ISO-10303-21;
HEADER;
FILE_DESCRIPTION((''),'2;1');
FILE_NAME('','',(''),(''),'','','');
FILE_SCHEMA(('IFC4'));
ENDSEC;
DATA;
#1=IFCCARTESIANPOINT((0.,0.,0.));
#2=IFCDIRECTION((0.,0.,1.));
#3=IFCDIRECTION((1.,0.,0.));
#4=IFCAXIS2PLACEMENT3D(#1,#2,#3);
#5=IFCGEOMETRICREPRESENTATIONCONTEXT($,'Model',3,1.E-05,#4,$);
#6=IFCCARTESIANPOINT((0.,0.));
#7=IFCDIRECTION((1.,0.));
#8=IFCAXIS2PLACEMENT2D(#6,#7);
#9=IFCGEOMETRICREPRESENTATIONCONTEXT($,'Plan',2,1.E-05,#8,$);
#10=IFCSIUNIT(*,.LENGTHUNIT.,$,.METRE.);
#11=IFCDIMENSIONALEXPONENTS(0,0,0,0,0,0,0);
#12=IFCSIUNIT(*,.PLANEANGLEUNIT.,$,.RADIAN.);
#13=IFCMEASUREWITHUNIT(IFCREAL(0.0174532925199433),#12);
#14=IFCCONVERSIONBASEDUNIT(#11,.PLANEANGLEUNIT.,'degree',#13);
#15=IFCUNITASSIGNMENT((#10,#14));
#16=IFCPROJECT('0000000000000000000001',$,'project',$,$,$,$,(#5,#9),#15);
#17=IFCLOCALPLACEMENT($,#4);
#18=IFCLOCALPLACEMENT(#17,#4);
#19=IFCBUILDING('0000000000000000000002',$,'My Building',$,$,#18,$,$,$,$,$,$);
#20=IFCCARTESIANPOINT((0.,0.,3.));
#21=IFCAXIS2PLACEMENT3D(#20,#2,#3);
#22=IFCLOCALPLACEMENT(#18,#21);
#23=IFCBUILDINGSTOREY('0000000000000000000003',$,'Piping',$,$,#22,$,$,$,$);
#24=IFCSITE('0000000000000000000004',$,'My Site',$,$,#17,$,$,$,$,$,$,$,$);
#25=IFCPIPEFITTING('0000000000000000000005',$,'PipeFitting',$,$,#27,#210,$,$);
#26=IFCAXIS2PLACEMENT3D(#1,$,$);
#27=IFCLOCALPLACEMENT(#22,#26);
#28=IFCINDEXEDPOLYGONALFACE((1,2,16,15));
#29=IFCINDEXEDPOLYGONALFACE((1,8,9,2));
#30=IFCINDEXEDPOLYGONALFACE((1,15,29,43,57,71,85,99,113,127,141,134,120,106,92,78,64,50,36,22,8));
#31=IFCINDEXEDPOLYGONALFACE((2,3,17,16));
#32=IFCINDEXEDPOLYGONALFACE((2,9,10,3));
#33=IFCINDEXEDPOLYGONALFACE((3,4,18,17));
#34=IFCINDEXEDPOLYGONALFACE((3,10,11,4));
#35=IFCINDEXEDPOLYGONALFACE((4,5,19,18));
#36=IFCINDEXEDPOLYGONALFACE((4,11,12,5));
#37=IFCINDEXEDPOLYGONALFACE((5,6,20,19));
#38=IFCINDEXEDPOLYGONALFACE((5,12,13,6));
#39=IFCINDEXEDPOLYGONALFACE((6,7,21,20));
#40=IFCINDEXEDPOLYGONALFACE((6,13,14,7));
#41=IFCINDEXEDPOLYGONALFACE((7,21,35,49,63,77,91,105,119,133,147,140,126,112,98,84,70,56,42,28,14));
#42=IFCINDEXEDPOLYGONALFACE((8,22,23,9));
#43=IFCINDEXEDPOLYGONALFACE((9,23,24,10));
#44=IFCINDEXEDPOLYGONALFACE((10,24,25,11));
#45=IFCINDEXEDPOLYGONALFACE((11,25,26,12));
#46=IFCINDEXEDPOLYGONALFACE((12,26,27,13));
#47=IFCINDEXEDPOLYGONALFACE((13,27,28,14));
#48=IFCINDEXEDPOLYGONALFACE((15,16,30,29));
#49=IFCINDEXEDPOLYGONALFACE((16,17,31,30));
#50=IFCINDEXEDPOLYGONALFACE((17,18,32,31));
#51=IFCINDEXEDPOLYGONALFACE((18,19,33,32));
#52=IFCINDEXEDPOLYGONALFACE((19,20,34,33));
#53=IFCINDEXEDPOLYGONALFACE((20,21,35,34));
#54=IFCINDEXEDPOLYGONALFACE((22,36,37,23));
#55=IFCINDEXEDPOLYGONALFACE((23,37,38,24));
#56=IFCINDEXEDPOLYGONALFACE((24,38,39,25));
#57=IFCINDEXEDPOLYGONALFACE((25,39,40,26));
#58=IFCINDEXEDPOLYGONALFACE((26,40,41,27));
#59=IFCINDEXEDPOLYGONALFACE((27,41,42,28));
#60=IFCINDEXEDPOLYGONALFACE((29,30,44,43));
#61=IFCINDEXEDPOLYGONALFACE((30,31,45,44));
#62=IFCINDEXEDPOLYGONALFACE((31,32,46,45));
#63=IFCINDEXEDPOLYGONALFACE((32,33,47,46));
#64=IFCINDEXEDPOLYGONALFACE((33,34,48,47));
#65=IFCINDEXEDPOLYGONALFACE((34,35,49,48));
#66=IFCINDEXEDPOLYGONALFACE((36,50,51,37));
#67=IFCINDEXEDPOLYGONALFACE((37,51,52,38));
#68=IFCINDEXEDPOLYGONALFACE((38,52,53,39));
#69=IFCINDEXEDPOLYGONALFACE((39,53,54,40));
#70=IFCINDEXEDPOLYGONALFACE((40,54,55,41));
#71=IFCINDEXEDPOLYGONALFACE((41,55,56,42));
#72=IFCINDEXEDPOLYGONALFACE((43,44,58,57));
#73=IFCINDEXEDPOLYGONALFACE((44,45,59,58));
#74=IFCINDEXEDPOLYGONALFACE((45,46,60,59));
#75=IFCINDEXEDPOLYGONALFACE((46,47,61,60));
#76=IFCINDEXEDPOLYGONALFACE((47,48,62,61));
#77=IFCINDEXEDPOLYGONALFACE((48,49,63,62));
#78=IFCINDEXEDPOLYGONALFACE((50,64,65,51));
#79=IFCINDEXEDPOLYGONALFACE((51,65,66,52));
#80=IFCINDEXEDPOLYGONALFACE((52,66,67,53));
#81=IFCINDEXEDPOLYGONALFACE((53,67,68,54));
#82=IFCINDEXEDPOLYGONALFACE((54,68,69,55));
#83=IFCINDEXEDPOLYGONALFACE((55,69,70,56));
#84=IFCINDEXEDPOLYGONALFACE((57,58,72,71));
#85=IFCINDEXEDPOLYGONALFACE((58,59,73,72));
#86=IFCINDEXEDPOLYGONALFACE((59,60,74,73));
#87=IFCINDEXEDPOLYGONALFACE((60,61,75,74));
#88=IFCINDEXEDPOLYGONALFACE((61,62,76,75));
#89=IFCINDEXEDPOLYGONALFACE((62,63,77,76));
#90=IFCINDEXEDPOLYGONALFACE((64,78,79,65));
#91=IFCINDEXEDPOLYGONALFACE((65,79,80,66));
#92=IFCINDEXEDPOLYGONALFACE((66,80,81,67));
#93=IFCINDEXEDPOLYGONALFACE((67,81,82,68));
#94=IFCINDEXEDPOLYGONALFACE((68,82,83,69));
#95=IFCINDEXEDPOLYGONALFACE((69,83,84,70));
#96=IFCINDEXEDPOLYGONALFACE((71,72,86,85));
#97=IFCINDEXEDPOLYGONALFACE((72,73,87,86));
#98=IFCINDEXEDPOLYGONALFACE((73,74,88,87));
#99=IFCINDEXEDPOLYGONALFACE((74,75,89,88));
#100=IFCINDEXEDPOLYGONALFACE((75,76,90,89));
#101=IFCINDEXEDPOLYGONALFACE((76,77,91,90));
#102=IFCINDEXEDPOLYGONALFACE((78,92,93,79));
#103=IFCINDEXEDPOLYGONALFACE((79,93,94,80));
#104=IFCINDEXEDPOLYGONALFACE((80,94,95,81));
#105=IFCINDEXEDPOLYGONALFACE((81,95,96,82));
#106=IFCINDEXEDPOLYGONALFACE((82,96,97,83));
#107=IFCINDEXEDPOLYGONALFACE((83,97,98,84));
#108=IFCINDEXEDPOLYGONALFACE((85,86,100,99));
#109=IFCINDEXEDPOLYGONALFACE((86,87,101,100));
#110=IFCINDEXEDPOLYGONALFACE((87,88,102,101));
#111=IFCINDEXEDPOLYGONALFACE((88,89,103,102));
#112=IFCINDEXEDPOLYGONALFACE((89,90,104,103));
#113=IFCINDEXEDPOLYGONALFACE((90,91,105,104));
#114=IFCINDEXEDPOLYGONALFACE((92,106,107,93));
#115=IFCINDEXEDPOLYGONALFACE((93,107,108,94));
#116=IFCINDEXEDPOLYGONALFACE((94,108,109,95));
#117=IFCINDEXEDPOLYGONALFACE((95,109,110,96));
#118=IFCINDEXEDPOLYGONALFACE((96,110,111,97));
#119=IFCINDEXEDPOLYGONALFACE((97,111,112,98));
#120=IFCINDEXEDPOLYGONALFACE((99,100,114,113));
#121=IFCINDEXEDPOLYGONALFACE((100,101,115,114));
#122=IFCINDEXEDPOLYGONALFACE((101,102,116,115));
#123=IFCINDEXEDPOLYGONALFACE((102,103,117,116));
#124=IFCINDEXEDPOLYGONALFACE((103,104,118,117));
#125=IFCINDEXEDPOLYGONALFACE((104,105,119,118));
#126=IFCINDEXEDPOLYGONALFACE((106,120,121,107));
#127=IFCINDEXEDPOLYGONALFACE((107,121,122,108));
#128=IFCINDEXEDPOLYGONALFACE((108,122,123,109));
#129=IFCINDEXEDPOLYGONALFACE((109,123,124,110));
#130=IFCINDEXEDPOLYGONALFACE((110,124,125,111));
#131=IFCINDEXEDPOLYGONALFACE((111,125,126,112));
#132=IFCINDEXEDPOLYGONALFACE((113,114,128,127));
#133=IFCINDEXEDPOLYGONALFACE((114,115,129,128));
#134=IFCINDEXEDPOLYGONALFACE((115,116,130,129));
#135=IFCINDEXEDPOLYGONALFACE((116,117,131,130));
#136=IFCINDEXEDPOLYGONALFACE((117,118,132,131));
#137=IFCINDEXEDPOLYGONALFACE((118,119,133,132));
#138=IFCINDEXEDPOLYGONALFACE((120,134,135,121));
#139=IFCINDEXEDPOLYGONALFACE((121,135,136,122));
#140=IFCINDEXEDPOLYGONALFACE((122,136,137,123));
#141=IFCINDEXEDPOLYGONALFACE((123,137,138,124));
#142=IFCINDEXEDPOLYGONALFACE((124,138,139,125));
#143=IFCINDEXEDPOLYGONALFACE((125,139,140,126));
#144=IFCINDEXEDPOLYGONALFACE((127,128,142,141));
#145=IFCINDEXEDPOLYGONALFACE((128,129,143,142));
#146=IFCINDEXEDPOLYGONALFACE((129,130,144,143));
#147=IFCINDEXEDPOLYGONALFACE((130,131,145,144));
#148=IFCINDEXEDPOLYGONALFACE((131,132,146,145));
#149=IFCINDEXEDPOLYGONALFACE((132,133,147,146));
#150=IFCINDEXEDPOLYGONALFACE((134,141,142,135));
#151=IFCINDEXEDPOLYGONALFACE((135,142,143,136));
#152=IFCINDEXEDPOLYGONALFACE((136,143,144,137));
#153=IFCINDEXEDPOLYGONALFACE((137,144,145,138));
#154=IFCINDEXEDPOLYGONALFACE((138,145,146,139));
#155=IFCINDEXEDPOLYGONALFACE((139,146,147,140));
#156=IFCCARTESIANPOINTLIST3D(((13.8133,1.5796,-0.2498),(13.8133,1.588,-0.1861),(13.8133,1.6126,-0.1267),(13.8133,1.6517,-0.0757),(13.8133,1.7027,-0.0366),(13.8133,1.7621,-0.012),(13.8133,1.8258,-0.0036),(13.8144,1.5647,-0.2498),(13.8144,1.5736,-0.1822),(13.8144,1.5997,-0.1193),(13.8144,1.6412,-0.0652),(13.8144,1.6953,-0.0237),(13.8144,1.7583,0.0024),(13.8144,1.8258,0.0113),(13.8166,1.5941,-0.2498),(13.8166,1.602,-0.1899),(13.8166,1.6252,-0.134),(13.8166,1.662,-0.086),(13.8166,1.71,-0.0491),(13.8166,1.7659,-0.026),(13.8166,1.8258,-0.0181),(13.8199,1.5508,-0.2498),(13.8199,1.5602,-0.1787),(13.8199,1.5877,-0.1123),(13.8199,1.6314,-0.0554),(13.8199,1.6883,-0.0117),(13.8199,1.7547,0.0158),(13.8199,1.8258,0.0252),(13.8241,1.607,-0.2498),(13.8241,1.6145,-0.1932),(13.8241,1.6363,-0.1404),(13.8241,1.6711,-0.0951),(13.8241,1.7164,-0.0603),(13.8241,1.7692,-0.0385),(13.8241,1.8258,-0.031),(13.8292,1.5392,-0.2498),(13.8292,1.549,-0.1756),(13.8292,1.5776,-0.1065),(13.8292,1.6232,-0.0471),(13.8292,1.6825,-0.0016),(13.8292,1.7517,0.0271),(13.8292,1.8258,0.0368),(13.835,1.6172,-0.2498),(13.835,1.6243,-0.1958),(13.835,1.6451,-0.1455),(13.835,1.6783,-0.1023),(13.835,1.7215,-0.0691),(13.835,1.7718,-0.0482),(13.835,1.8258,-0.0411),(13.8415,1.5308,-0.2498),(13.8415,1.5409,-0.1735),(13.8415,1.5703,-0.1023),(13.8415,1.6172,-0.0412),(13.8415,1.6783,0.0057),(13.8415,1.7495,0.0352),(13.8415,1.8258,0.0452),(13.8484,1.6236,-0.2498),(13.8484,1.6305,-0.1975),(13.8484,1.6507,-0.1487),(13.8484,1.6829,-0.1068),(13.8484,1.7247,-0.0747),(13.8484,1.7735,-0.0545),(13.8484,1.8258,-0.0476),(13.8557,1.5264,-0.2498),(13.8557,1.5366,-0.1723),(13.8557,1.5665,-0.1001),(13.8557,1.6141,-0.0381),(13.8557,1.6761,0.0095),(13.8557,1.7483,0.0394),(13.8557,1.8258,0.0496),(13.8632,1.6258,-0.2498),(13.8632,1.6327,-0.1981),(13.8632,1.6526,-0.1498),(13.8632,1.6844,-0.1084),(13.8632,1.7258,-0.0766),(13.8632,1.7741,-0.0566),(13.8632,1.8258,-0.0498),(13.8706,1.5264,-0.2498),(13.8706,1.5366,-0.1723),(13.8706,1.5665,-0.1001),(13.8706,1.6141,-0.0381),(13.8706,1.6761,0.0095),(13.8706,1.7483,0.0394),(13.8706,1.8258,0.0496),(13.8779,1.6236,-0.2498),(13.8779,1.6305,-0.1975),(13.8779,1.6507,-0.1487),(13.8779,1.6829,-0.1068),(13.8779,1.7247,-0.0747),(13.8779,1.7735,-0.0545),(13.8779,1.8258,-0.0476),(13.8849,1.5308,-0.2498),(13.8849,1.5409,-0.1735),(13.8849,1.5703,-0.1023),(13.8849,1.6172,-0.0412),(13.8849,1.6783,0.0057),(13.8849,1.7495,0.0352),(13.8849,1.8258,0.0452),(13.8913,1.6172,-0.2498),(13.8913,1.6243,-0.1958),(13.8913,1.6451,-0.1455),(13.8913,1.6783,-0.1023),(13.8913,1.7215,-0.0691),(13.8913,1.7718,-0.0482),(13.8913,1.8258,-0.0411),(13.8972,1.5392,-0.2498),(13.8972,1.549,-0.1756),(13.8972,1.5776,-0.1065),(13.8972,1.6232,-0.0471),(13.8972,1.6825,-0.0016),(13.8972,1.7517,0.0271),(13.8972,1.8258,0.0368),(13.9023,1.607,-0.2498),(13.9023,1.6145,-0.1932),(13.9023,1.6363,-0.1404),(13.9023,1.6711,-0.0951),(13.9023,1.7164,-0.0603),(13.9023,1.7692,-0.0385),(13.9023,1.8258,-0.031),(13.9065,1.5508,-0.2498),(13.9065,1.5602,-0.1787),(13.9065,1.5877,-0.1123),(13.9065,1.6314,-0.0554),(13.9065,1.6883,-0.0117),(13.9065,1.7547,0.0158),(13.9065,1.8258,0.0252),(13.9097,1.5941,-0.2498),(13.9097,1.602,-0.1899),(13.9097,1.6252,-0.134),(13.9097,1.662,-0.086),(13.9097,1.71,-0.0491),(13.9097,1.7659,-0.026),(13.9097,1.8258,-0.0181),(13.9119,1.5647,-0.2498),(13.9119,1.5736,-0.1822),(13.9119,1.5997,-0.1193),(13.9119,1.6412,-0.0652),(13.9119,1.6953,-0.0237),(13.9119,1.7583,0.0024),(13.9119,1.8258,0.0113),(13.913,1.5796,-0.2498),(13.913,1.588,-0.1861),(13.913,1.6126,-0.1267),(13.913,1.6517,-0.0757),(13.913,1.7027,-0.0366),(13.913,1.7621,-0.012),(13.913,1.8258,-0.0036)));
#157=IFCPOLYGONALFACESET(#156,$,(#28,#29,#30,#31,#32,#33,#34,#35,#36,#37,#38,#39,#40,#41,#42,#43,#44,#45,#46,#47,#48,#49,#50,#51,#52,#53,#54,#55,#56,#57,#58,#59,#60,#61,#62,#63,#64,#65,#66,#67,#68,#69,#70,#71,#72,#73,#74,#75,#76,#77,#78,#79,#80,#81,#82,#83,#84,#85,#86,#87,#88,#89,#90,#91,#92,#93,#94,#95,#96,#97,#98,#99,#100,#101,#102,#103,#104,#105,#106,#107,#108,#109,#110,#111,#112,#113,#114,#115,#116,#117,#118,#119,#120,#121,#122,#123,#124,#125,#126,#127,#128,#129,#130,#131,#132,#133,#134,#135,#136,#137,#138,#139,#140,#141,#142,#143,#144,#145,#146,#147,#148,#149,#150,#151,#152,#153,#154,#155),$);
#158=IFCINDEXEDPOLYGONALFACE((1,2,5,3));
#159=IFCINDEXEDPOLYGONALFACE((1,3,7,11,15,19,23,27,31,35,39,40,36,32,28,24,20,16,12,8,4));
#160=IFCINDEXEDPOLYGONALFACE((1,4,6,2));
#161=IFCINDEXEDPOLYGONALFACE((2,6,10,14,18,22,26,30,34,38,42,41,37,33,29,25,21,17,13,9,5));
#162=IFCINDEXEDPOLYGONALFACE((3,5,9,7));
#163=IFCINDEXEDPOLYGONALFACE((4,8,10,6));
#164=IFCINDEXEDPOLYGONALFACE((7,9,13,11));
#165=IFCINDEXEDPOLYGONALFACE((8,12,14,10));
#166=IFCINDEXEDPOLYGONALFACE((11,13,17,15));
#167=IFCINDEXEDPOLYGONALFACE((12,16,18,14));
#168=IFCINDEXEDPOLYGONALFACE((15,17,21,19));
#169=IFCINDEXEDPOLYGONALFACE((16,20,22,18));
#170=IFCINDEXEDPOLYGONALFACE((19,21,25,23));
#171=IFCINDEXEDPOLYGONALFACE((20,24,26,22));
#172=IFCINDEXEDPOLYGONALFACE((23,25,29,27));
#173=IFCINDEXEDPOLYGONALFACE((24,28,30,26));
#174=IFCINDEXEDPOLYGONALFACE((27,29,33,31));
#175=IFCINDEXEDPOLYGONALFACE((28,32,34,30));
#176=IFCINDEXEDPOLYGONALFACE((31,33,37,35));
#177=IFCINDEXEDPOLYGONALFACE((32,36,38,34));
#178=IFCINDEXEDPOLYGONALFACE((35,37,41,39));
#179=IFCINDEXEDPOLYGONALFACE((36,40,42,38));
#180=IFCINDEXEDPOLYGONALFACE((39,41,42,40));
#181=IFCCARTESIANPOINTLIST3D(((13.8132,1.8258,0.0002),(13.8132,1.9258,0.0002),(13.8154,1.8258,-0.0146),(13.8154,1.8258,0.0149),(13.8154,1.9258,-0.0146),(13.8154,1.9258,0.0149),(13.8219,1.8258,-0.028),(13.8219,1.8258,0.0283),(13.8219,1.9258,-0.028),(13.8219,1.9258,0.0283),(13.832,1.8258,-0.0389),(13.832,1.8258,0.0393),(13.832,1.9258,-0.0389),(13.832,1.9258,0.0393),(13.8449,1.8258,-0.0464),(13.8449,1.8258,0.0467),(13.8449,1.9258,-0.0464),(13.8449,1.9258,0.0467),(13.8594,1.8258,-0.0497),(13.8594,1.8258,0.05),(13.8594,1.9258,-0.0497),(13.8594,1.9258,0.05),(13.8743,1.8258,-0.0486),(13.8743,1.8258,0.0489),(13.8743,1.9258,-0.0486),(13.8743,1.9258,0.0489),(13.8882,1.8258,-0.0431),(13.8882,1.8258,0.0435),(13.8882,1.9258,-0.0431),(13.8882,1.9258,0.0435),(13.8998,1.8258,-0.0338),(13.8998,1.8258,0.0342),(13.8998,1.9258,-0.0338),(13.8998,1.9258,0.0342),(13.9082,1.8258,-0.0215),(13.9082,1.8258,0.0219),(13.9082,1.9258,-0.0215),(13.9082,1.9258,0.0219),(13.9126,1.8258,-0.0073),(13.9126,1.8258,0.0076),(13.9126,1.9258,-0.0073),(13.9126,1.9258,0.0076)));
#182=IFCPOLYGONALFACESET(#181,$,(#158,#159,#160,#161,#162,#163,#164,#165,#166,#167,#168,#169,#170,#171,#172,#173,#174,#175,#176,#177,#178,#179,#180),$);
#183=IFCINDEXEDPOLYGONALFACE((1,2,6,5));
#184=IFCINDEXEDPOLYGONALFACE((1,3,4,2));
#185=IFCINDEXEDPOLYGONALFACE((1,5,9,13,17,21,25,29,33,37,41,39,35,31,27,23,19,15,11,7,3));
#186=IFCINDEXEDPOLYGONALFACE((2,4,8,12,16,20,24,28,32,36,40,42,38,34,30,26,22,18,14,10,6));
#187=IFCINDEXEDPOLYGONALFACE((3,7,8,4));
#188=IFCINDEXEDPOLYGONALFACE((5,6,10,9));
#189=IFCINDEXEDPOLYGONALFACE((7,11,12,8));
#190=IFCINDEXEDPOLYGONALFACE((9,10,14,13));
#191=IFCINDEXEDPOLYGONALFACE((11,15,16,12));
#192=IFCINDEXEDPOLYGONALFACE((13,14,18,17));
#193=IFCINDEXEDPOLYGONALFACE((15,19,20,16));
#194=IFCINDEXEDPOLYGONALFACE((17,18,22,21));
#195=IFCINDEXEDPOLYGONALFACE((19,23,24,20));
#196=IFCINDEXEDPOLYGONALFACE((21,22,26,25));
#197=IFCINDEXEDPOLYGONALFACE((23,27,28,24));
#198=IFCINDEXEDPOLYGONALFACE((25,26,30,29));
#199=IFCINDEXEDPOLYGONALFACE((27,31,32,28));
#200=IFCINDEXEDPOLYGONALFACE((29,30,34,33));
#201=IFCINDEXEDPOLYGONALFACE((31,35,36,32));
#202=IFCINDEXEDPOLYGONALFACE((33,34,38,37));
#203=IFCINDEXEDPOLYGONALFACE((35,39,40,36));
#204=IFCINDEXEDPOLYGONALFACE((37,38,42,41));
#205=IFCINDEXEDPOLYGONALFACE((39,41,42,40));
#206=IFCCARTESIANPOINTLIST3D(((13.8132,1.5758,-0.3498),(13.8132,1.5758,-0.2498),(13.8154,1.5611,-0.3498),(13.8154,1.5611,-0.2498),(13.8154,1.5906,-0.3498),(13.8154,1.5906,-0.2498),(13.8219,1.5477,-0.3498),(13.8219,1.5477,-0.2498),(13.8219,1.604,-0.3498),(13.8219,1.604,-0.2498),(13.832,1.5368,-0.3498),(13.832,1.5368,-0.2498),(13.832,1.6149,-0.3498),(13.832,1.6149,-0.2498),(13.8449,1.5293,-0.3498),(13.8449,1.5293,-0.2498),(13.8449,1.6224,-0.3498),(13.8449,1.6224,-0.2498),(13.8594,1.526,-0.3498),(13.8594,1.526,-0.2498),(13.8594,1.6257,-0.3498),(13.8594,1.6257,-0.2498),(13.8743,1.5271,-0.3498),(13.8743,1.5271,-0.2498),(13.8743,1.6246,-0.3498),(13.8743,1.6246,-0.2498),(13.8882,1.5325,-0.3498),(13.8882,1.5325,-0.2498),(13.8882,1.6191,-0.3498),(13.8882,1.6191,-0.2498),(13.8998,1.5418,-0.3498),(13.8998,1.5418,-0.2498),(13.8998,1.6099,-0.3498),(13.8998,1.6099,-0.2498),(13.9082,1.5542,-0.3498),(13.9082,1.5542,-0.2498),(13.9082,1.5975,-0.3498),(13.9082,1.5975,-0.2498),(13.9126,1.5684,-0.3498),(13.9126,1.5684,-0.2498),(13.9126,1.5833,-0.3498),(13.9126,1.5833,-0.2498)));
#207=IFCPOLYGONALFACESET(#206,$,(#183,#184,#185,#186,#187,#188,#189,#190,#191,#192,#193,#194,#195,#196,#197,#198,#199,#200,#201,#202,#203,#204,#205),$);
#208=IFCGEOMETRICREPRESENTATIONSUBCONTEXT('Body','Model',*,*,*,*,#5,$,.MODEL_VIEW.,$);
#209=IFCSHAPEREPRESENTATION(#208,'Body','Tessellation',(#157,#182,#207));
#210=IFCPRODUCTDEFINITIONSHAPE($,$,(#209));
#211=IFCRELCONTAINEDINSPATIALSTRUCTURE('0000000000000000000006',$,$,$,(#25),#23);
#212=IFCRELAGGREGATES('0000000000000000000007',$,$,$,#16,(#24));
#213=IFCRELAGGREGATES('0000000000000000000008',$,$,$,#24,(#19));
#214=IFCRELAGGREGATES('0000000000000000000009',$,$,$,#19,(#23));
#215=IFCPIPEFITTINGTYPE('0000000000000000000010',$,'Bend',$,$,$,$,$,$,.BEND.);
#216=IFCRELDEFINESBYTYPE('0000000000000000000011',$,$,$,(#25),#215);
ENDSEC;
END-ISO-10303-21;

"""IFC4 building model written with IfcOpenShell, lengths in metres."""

from ifc_helpers import new_model, entity, si_unit, converted_unit, frame, origin_with_axes, origin_2d_with_axis, place, context, subcontext, project, spatial, circle, extrude, source, transform, mapped, type_object, type_shapes, element, save


model = new_model("IFC4")

# Units and contexts
model_context = context("Model", 3, precision=1e-05, world=origin_with_axes())
plan_context = context("Plan", 2, precision=1e-05, world=origin_2d_with_axis())
body_context = subcontext(model_context, "Body", "Model", "MODEL_VIEW")
ifc_project = project(units=[si_unit("LENGTHUNIT", "METRE"), converted_unit("PLANEANGLEUNIT", "degree", entity("IfcReal", 0.0174532925199433), si_unit("PLANEANGLEUNIT", "RADIAN"), dimensions=[0, 0, 0, 0, 0, 0, 0])], contexts=[model_context, plan_context])

# Site, building, storey
site_placement = place(None, origin_with_axes())
site = spatial("IfcSite", under=ifc_project, at=site_placement, Name="My Site")
building_placement = place(site_placement, origin_with_axes())
building = spatial("IfcBuilding", under=site, at=building_placement, Name="My Building")
storey_placement = place(building_placement, frame((0.0, 0.0, 3.0), z_axis=(0.0, 0.0, 1.0), x_axis=(1.0, 0.0, 0.0)))
storey = spatial("IfcBuildingStorey", under=building, at=storey_placement, Name="Piping")

# Pipe fitting
pipe_fitting_type = type_object("IfcPipeFittingType", Name="Bend", PredefinedType="BEND")
shared_shape = source(origin_with_axes(), body_context, "Body", "SolidModel", [
    entity("IfcSweptDiskSolid", entity("IfcIndexedPolyCurve", entity("IfcCartesianPointList3D", [[0.0, 0.0, -0.1], [0.0, -0.0732, -0.2768], [0.0, -0.25, -0.35]]), [entity("IfcArcIndex", [1, 2, 3])]), 0.05),
    extrude(circle(Radius=0.05), origin_with_axes(), (0.0, 0.0, -1.0), 0.1),
    extrude(circle(Radius=0.05), frame((0.0, -0.25, -0.35), z_axis=(0.0, -1.0, 0.0), x_axis=(1.0, 0.0, 0.0)), (0.0, 0.0, 1.0), 0.1),
])
type_shapes(pipe_fitting_type, [shared_shape])
for number, where, z_axis, x_axis, name in (
    (1, (13.8632, 1.9258, 0.0002), (0.0, 1.0, 0.0), (-1.0, 0.0, 0.0), "PipeFitting"),
):
    element("IfcPipeFitting", number, at=place(storey_placement, frame(where, z_axis=z_axis, x_axis=x_axis)), inside=storey, type_object=pipe_fitting_type, Name=name, context=body_context, shape_type="MappedRepresentation", body=[
        mapped(shared_shape, transform((0.0, 0.0, 0.0), x_axis=(1.0, 0.0, 0.0), y_axis=(0.0, 1.0, 0.0), z_axis=(0.0, 0.0, 1.0), scale=1.0)),
    ])

save(model, "model.ifc")
